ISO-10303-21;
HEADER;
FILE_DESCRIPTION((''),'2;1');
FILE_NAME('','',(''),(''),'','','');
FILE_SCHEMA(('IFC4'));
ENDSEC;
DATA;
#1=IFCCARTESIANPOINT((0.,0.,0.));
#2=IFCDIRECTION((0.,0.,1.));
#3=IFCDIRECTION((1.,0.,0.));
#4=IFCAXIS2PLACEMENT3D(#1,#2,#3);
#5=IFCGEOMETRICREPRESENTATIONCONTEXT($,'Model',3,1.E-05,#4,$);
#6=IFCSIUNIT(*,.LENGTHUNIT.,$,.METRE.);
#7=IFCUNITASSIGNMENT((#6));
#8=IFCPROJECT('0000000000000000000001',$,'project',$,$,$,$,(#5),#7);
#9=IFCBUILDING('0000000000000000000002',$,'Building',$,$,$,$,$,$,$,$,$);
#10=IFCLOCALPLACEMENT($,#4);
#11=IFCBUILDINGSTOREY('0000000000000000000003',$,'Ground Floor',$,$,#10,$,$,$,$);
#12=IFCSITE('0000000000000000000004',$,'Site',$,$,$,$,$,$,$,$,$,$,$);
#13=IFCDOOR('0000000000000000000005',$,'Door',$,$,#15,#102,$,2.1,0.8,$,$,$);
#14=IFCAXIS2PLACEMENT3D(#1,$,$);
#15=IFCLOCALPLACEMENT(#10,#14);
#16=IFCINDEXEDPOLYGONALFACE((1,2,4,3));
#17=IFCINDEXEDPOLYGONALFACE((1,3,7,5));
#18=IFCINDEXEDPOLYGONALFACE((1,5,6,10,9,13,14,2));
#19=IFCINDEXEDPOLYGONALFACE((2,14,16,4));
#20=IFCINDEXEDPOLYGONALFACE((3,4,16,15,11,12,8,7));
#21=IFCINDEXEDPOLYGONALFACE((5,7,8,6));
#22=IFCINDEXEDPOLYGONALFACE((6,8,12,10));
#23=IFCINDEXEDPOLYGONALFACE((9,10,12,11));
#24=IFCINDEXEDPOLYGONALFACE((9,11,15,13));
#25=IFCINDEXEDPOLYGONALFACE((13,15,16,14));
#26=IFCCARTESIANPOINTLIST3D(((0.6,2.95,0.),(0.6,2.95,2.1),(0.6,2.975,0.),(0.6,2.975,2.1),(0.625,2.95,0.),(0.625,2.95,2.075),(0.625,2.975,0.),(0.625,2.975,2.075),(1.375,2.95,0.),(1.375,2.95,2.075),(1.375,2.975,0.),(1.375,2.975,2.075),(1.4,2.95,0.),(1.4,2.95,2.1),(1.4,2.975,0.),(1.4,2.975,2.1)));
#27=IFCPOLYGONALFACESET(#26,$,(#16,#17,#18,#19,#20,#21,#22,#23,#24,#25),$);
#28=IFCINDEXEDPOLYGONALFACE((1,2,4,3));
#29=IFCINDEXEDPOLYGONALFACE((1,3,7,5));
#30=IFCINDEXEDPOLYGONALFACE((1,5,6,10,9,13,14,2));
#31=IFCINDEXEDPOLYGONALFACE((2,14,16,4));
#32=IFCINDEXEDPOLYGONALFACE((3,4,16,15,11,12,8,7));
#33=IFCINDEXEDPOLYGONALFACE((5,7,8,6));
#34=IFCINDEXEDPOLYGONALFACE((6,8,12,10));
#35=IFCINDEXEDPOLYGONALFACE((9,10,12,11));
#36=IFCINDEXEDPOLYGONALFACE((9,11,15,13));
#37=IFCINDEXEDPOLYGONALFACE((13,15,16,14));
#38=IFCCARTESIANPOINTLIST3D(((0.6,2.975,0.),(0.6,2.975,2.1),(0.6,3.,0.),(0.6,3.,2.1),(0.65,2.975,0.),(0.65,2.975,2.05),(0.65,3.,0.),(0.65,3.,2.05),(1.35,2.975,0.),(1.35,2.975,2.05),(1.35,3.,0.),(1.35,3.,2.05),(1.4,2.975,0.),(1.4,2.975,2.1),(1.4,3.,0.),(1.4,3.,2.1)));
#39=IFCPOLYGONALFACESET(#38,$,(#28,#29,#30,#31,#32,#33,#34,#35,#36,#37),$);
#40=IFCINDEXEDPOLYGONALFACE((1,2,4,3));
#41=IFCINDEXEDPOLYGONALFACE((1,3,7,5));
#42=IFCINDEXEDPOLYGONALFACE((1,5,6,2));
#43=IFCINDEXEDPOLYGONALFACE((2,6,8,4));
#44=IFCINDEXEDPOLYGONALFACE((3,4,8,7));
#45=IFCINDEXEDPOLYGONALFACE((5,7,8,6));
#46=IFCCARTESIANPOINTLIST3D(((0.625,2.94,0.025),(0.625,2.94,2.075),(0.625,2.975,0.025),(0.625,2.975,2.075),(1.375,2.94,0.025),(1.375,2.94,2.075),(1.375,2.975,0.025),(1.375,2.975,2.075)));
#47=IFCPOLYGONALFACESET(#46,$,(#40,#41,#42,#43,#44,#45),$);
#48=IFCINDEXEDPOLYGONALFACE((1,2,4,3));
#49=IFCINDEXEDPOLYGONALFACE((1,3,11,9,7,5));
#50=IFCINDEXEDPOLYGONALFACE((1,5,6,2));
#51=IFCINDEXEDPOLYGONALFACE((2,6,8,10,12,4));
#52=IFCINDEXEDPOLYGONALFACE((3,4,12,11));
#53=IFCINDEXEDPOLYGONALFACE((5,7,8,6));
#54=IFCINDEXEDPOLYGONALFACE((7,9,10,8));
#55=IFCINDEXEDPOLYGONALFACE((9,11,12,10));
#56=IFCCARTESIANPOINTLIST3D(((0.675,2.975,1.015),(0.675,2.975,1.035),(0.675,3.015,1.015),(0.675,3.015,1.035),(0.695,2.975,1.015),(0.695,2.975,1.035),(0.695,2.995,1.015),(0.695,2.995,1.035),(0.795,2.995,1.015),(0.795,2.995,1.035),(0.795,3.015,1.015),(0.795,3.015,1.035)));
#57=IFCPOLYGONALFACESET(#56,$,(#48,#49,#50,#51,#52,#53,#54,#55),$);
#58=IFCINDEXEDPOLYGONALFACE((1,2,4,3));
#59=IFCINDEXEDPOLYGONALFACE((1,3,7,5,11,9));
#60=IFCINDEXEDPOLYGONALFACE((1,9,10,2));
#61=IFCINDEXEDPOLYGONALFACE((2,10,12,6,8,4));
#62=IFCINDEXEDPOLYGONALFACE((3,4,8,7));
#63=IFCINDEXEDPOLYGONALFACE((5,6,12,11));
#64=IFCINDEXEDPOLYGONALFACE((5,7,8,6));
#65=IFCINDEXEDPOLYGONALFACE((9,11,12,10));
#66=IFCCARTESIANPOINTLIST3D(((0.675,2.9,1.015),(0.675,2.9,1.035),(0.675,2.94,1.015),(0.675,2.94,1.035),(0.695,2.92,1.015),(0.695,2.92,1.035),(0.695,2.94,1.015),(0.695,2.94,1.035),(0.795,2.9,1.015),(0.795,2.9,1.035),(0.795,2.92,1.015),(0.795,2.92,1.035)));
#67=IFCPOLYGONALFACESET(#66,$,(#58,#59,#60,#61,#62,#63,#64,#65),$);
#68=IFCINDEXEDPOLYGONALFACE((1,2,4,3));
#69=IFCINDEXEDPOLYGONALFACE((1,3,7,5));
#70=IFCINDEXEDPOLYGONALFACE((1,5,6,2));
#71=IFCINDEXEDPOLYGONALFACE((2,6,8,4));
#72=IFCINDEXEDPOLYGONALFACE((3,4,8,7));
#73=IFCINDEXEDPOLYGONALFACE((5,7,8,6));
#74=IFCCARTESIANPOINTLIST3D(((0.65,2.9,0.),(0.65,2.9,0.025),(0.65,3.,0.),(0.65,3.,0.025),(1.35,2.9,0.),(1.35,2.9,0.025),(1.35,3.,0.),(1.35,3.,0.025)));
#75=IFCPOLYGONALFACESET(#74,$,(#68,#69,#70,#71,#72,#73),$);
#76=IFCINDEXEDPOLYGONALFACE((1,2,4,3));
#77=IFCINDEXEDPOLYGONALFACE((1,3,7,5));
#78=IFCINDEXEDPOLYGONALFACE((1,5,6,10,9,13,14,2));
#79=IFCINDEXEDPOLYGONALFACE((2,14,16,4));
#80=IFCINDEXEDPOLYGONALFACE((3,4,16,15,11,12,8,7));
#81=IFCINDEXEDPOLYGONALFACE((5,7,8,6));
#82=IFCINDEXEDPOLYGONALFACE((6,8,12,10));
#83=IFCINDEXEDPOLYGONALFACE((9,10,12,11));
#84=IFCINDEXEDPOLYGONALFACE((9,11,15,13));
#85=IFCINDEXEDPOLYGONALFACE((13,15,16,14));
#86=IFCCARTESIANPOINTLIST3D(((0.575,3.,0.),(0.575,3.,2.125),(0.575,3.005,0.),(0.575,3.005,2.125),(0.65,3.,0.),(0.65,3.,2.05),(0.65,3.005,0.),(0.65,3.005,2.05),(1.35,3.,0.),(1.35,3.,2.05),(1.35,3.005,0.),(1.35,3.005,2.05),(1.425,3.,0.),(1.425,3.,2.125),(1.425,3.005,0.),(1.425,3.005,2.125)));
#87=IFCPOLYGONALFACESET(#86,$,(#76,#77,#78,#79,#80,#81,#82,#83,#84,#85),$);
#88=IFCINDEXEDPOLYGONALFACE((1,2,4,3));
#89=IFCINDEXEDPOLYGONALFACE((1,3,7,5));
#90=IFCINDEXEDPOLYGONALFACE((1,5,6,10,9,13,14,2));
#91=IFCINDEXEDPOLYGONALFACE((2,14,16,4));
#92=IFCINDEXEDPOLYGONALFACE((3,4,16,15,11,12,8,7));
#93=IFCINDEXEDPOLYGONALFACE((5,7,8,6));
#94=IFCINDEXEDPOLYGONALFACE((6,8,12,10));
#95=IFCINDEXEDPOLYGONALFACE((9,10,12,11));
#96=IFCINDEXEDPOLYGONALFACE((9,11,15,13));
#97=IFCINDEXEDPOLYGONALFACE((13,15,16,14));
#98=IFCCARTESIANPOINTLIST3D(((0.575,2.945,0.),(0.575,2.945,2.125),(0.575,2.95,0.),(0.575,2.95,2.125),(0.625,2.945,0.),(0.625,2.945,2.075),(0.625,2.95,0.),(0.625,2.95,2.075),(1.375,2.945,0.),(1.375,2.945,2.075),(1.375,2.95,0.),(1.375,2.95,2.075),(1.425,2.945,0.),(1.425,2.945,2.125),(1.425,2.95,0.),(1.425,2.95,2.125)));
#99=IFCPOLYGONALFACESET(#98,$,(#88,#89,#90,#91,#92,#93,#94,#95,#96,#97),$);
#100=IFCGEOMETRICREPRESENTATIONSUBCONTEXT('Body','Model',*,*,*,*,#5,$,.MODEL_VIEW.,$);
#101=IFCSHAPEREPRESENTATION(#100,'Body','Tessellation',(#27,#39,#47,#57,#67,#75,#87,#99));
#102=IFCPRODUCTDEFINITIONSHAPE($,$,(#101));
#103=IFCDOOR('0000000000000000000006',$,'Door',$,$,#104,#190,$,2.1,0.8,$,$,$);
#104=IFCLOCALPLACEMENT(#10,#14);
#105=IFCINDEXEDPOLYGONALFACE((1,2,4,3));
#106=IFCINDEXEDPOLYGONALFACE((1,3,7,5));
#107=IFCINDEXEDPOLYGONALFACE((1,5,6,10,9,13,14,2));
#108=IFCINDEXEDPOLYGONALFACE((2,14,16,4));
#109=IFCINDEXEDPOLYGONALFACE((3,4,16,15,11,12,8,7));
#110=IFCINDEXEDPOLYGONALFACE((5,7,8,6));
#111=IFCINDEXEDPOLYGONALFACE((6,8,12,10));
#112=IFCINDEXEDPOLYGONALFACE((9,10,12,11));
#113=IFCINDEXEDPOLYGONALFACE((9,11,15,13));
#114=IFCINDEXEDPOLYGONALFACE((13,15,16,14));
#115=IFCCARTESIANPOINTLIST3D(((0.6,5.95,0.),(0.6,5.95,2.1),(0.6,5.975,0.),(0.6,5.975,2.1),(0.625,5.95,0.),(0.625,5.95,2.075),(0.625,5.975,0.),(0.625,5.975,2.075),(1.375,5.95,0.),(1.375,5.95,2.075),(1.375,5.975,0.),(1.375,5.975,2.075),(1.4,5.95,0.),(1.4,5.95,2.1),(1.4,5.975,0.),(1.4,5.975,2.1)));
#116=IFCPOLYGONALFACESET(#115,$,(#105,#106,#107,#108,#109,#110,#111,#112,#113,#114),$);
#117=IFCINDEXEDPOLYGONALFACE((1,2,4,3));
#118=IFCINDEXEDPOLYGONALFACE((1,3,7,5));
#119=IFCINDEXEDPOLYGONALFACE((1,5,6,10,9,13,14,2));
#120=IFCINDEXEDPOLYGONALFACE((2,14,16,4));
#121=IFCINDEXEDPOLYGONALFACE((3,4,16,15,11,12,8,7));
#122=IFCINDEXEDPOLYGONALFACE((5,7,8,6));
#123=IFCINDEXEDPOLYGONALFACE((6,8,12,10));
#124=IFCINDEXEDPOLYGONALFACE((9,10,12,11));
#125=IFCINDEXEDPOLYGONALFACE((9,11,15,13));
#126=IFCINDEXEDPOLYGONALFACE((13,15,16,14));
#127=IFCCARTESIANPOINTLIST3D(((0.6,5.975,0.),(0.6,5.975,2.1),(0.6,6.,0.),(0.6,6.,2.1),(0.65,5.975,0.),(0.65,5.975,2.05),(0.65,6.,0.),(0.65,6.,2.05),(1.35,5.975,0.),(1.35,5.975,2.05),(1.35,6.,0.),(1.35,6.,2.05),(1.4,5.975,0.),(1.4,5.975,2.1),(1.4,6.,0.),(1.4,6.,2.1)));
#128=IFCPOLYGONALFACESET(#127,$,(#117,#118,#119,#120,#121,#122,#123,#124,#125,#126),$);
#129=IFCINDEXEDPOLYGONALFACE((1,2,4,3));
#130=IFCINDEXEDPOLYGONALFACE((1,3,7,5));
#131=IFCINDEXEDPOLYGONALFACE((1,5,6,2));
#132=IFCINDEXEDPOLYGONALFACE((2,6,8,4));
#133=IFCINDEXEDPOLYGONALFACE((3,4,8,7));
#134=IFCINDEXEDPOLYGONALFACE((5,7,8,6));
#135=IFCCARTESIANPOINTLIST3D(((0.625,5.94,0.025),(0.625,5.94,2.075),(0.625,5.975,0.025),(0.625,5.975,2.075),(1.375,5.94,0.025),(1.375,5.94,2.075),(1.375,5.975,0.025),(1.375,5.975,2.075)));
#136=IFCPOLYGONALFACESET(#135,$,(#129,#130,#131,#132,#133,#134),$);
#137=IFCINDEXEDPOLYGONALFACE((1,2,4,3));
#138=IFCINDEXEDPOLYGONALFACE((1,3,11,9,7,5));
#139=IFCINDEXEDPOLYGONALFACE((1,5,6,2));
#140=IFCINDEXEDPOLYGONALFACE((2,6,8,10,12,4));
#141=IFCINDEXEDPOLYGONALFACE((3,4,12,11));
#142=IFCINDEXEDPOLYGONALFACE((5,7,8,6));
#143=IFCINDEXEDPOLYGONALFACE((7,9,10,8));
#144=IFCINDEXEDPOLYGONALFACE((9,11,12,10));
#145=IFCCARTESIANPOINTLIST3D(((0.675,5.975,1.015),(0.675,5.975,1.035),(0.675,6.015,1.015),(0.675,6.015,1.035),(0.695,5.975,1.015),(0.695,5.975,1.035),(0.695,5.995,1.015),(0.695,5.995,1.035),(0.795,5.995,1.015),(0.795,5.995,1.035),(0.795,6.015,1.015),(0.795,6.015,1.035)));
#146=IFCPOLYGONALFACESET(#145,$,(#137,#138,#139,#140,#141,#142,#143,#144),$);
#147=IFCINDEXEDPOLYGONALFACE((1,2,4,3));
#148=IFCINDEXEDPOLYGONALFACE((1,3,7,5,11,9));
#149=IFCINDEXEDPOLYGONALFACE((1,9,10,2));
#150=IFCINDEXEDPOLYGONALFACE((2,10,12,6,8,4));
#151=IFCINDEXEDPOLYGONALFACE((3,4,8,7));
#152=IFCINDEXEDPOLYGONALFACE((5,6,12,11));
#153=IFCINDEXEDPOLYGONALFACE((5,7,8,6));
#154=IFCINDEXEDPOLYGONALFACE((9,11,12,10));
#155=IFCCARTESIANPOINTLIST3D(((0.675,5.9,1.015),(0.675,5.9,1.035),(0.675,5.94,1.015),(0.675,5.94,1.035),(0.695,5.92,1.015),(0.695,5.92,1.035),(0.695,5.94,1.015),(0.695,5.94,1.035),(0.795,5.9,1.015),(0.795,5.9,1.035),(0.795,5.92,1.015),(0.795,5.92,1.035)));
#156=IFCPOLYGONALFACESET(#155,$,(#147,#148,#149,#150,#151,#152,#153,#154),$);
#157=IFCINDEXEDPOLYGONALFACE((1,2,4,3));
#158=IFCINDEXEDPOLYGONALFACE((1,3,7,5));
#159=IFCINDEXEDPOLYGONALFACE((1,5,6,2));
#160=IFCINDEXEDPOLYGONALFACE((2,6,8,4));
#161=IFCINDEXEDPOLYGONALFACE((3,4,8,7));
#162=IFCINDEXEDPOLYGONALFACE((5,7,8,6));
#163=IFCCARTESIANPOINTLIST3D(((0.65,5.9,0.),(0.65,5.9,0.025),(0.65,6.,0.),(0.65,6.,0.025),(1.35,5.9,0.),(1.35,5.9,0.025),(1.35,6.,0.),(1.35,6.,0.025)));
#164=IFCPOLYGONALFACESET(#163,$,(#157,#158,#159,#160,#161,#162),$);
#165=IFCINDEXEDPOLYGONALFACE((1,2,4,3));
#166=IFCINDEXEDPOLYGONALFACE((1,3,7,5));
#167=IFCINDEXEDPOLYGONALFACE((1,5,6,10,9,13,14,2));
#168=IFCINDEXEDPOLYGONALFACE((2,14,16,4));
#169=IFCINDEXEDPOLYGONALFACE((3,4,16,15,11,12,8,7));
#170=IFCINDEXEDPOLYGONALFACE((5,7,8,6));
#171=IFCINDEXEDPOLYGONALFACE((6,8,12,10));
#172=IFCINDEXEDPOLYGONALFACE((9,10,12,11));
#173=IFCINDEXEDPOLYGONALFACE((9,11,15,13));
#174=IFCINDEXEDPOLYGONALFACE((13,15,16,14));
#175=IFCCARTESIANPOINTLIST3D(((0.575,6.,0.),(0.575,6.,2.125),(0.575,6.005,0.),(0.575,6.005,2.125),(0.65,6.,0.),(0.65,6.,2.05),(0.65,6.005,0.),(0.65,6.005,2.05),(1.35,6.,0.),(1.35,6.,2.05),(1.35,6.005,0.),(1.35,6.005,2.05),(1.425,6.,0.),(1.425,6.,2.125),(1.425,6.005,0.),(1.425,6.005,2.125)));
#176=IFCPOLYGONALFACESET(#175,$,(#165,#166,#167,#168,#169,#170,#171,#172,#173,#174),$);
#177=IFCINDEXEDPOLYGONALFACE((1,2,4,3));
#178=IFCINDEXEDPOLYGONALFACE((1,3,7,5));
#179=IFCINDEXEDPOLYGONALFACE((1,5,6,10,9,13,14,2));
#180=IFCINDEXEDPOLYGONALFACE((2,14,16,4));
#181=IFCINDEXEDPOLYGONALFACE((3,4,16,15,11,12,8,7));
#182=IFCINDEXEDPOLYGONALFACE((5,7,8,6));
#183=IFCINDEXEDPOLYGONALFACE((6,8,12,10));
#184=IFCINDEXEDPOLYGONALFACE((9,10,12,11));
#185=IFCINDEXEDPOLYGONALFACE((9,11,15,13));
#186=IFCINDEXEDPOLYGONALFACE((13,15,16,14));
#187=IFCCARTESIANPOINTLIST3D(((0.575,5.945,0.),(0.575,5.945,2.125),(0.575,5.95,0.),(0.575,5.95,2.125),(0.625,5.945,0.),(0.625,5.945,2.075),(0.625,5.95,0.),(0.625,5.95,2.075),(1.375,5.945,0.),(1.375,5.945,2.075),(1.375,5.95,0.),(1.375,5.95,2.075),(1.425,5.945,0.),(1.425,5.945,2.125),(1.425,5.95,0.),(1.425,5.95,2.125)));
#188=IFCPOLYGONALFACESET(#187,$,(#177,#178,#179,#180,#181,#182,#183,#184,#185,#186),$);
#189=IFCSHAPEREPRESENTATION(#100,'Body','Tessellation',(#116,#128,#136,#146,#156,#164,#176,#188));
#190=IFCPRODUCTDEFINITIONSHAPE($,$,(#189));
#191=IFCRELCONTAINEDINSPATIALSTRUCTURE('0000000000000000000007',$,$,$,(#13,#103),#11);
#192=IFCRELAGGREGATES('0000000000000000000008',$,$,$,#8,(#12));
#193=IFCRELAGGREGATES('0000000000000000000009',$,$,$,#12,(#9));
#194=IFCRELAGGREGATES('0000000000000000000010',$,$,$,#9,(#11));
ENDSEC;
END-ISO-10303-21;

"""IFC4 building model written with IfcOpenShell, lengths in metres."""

from ifc_helpers import new_model, si_unit, frame, origin_with_axes, place, context, subcontext, project, spatial, line, indexed_curve, outline, extrude, element, save


model = new_model("IFC4")

# Units and contexts
model_context = context("Model", 3, precision=1e-05, world=origin_with_axes())
body_context = subcontext(model_context, "Body", "Model", "MODEL_VIEW")
ifc_project = project(units=[si_unit("LENGTHUNIT", "METRE")], contexts=[model_context])

# Site, building, storey
site = spatial("IfcSite", under=ifc_project, Name="Site")
building = spatial("IfcBuilding", under=site, Name="Building")
storey_placement = place(None, origin_with_axes())
storey = spatial("IfcBuildingStorey", under=building, at=storey_placement, Name="Ground Floor")

# Doors
door_1_placement = place(storey_placement, frame((1.4, 3.0, 0.0), z_axis=(0.0, 0.0, 1.0), x_axis=(-1.0, 0.0, 0.0)))
element("IfcDoor", 1, at=door_1_placement, inside=storey, Name="Door", OverallHeight=2.1, OverallWidth=0.8, context=body_context, shape_type="SweptSolid", body=[
    extrude(outline(indexed_curve([(0.0, 0.0), (0.0, 2.1), (0.8, 2.1), (0.8, 0.0), (0.775, 0.0), (0.775, 2.075), (0.025, 2.075), (0.025, 0.0)], segments=[line(1, 2, 3, 4, 5, 6, 7, 8, 1)])), frame((0.0, 0.025, 0.0), z_axis=(0.0, -1.0, 0.0), x_axis=(1.0, 0.0, 0.0)), (0.0, 0.0, -1.0), 0.025),
    extrude(outline(indexed_curve([(0.0, 0.0), (0.0, 2.1), (0.8, 2.1), (0.8, 0.0), (0.75, 0.0), (0.75, 2.05), (0.05, 2.05), (0.05, 0.0)], segments=[line(1, 2, 3, 4, 5, 6, 7, 8, 1)])), frame((0.0, 0.0, 0.0), z_axis=(0.0, -1.0, 0.0), x_axis=(1.0, 0.0, 0.0)), (0.0, 0.0, -1.0), 0.025),
    extrude(outline(indexed_curve([(0.0, 0.0), (0.75, 0.0), (0.75, 0.035), (0.0, 0.035)], segments=[line(1, 2, 3, 4, 1)])), frame((0.025, 0.025, 0.025), z_axis=(0.0, 0.0, 1.0), x_axis=(1.0, 0.0, 0.0)), (0.0, 0.0, 1.0), 2.05),
    extrude(outline(indexed_curve([(0.0, 0.0), (0.0, -0.04), (-0.12, -0.04), (-0.12, -0.02), (-0.02, -0.02), (-0.02, 0.0)], segments=[line(1, 2, 3, 4, 5, 6, 1)])), frame((0.725, 0.025, 1.015), z_axis=(0.0, 0.0, 1.0), x_axis=(1.0, 0.0, 0.0)), (0.0, 0.0, 1.0), 0.02),
    extrude(outline(indexed_curve([(0.0, 0.0), (0.0, 0.04), (-0.12, 0.04), (-0.12, 0.02), (-0.02, 0.02), (-0.02, 0.0)], segments=[line(1, 2, 3, 4, 5, 6, 1)])), frame((0.725, 0.06, 1.015), z_axis=(0.0, 0.0, 1.0), x_axis=(1.0, 0.0, 0.0)), (0.0, 0.0, 1.0), 0.02),
    extrude(outline(indexed_curve([(0.0, 0.0), (0.7, 0.0), (0.7, 0.1), (0.0, 0.1)], segments=[line(1, 2, 3, 4, 1)])), frame((0.05, 0.0, 0.0), z_axis=(0.0, 0.0, 1.0), x_axis=(1.0, 0.0, 0.0)), (0.0, 0.0, 1.0), 0.025),
    extrude(outline(indexed_curve([(0.0, 0.0), (0.0, 2.125), (0.85, 2.125), (0.85, 0.0), (0.775, 0.0), (0.775, 2.05), (0.075, 2.05), (0.075, 0.0)], segments=[line(1, 2, 3, 4, 5, 6, 7, 8, 1)])), frame((-0.025, -0.005, 0.0), z_axis=(0.0, -1.0, 0.0), x_axis=(1.0, 0.0, 0.0)), (0.0, 0.0, -1.0), 0.005),
    extrude(outline(indexed_curve([(0.0, 0.0), (0.0, 2.125), (0.85, 2.125), (0.85, 0.0), (0.8, 0.0), (0.8, 2.075), (0.05, 2.075), (0.05, 0.0)], segments=[line(1, 2, 3, 4, 5, 6, 7, 8, 1)])), frame((-0.025, 0.05, 0.0), z_axis=(0.0, -1.0, 0.0), x_axis=(1.0, 0.0, 0.0)), (0.0, 0.0, -1.0), 0.005),
])
door_2_placement = place(storey_placement, frame((1.4, 6.0, 0.0), z_axis=(0.0, 0.0, 1.0), x_axis=(-1.0, 0.0, 0.0)))
element("IfcDoor", 2, at=door_2_placement, inside=storey, Name="Door", OverallHeight=2.1, OverallWidth=0.8, context=body_context, shape_type="SweptSolid", body=[
    extrude(outline(indexed_curve([(0.0, 0.0), (0.0, 2.1), (0.8, 2.1), (0.8, 0.0), (0.775, 0.0), (0.775, 2.075), (0.025, 2.075), (0.025, 0.0)], segments=[line(1, 2, 3, 4, 5, 6, 7, 8, 1)])), frame((0.0, 0.025, 0.0), z_axis=(0.0, -1.0, 0.0), x_axis=(1.0, 0.0, 0.0)), (0.0, 0.0, -1.0), 0.025),
    extrude(outline(indexed_curve([(0.0, 0.0), (0.0, 2.1), (0.8, 2.1), (0.8, 0.0), (0.75, 0.0), (0.75, 2.05), (0.05, 2.05), (0.05, 0.0)], segments=[line(1, 2, 3, 4, 5, 6, 7, 8, 1)])), frame((0.0, 0.0, 0.0), z_axis=(0.0, -1.0, 0.0), x_axis=(1.0, 0.0, 0.0)), (0.0, 0.0, -1.0), 0.025),
    extrude(outline(indexed_curve([(0.0, 0.0), (0.75, 0.0), (0.75, 0.035), (0.0, 0.035)], segments=[line(1, 2, 3, 4, 1)])), frame((0.025, 0.025, 0.025), z_axis=(0.0, 0.0, 1.0), x_axis=(1.0, 0.0, 0.0)), (0.0, 0.0, 1.0), 2.05),
    extrude(outline(indexed_curve([(0.0, 0.0), (0.0, -0.04), (-0.12, -0.04), (-0.12, -0.02), (-0.02, -0.02), (-0.02, 0.0)], segments=[line(1, 2, 3, 4, 5, 6, 1)])), frame((0.725, 0.025, 1.015), z_axis=(0.0, 0.0, 1.0), x_axis=(1.0, 0.0, 0.0)), (0.0, 0.0, 1.0), 0.02),
    extrude(outline(indexed_curve([(0.0, 0.0), (0.0, 0.04), (-0.12, 0.04), (-0.12, 0.02), (-0.02, 0.02), (-0.02, 0.0)], segments=[line(1, 2, 3, 4, 5, 6, 1)])), frame((0.725, 0.06, 1.015), z_axis=(0.0, 0.0, 1.0), x_axis=(1.0, 0.0, 0.0)), (0.0, 0.0, 1.0), 0.02),
    extrude(outline(indexed_curve([(0.0, 0.0), (0.7, 0.0), (0.7, 0.1), (0.0, 0.1)], segments=[line(1, 2, 3, 4, 1)])), frame((0.05, 0.0, 0.0), z_axis=(0.0, 0.0, 1.0), x_axis=(1.0, 0.0, 0.0)), (0.0, 0.0, 1.0), 0.025),
    extrude(outline(indexed_curve([(0.0, 0.0), (0.0, 2.125), (0.85, 2.125), (0.85, 0.0), (0.775, 0.0), (0.775, 2.05), (0.075, 2.05), (0.075, 0.0)], segments=[line(1, 2, 3, 4, 5, 6, 7, 8, 1)])), frame((-0.025, -0.005, 0.0), z_axis=(0.0, -1.0, 0.0), x_axis=(1.0, 0.0, 0.0)), (0.0, 0.0, -1.0), 0.005),
    extrude(outline(indexed_curve([(0.0, 0.0), (0.0, 2.125), (0.85, 2.125), (0.85, 0.0), (0.8, 0.0), (0.8, 2.075), (0.05, 2.075), (0.05, 0.0)], segments=[line(1, 2, 3, 4, 5, 6, 7, 8, 1)])), frame((-0.025, 0.05, 0.0), z_axis=(0.0, -1.0, 0.0), x_axis=(1.0, 0.0, 0.0)), (0.0, 0.0, -1.0), 0.005),
])

save(model, "model.ifc")
